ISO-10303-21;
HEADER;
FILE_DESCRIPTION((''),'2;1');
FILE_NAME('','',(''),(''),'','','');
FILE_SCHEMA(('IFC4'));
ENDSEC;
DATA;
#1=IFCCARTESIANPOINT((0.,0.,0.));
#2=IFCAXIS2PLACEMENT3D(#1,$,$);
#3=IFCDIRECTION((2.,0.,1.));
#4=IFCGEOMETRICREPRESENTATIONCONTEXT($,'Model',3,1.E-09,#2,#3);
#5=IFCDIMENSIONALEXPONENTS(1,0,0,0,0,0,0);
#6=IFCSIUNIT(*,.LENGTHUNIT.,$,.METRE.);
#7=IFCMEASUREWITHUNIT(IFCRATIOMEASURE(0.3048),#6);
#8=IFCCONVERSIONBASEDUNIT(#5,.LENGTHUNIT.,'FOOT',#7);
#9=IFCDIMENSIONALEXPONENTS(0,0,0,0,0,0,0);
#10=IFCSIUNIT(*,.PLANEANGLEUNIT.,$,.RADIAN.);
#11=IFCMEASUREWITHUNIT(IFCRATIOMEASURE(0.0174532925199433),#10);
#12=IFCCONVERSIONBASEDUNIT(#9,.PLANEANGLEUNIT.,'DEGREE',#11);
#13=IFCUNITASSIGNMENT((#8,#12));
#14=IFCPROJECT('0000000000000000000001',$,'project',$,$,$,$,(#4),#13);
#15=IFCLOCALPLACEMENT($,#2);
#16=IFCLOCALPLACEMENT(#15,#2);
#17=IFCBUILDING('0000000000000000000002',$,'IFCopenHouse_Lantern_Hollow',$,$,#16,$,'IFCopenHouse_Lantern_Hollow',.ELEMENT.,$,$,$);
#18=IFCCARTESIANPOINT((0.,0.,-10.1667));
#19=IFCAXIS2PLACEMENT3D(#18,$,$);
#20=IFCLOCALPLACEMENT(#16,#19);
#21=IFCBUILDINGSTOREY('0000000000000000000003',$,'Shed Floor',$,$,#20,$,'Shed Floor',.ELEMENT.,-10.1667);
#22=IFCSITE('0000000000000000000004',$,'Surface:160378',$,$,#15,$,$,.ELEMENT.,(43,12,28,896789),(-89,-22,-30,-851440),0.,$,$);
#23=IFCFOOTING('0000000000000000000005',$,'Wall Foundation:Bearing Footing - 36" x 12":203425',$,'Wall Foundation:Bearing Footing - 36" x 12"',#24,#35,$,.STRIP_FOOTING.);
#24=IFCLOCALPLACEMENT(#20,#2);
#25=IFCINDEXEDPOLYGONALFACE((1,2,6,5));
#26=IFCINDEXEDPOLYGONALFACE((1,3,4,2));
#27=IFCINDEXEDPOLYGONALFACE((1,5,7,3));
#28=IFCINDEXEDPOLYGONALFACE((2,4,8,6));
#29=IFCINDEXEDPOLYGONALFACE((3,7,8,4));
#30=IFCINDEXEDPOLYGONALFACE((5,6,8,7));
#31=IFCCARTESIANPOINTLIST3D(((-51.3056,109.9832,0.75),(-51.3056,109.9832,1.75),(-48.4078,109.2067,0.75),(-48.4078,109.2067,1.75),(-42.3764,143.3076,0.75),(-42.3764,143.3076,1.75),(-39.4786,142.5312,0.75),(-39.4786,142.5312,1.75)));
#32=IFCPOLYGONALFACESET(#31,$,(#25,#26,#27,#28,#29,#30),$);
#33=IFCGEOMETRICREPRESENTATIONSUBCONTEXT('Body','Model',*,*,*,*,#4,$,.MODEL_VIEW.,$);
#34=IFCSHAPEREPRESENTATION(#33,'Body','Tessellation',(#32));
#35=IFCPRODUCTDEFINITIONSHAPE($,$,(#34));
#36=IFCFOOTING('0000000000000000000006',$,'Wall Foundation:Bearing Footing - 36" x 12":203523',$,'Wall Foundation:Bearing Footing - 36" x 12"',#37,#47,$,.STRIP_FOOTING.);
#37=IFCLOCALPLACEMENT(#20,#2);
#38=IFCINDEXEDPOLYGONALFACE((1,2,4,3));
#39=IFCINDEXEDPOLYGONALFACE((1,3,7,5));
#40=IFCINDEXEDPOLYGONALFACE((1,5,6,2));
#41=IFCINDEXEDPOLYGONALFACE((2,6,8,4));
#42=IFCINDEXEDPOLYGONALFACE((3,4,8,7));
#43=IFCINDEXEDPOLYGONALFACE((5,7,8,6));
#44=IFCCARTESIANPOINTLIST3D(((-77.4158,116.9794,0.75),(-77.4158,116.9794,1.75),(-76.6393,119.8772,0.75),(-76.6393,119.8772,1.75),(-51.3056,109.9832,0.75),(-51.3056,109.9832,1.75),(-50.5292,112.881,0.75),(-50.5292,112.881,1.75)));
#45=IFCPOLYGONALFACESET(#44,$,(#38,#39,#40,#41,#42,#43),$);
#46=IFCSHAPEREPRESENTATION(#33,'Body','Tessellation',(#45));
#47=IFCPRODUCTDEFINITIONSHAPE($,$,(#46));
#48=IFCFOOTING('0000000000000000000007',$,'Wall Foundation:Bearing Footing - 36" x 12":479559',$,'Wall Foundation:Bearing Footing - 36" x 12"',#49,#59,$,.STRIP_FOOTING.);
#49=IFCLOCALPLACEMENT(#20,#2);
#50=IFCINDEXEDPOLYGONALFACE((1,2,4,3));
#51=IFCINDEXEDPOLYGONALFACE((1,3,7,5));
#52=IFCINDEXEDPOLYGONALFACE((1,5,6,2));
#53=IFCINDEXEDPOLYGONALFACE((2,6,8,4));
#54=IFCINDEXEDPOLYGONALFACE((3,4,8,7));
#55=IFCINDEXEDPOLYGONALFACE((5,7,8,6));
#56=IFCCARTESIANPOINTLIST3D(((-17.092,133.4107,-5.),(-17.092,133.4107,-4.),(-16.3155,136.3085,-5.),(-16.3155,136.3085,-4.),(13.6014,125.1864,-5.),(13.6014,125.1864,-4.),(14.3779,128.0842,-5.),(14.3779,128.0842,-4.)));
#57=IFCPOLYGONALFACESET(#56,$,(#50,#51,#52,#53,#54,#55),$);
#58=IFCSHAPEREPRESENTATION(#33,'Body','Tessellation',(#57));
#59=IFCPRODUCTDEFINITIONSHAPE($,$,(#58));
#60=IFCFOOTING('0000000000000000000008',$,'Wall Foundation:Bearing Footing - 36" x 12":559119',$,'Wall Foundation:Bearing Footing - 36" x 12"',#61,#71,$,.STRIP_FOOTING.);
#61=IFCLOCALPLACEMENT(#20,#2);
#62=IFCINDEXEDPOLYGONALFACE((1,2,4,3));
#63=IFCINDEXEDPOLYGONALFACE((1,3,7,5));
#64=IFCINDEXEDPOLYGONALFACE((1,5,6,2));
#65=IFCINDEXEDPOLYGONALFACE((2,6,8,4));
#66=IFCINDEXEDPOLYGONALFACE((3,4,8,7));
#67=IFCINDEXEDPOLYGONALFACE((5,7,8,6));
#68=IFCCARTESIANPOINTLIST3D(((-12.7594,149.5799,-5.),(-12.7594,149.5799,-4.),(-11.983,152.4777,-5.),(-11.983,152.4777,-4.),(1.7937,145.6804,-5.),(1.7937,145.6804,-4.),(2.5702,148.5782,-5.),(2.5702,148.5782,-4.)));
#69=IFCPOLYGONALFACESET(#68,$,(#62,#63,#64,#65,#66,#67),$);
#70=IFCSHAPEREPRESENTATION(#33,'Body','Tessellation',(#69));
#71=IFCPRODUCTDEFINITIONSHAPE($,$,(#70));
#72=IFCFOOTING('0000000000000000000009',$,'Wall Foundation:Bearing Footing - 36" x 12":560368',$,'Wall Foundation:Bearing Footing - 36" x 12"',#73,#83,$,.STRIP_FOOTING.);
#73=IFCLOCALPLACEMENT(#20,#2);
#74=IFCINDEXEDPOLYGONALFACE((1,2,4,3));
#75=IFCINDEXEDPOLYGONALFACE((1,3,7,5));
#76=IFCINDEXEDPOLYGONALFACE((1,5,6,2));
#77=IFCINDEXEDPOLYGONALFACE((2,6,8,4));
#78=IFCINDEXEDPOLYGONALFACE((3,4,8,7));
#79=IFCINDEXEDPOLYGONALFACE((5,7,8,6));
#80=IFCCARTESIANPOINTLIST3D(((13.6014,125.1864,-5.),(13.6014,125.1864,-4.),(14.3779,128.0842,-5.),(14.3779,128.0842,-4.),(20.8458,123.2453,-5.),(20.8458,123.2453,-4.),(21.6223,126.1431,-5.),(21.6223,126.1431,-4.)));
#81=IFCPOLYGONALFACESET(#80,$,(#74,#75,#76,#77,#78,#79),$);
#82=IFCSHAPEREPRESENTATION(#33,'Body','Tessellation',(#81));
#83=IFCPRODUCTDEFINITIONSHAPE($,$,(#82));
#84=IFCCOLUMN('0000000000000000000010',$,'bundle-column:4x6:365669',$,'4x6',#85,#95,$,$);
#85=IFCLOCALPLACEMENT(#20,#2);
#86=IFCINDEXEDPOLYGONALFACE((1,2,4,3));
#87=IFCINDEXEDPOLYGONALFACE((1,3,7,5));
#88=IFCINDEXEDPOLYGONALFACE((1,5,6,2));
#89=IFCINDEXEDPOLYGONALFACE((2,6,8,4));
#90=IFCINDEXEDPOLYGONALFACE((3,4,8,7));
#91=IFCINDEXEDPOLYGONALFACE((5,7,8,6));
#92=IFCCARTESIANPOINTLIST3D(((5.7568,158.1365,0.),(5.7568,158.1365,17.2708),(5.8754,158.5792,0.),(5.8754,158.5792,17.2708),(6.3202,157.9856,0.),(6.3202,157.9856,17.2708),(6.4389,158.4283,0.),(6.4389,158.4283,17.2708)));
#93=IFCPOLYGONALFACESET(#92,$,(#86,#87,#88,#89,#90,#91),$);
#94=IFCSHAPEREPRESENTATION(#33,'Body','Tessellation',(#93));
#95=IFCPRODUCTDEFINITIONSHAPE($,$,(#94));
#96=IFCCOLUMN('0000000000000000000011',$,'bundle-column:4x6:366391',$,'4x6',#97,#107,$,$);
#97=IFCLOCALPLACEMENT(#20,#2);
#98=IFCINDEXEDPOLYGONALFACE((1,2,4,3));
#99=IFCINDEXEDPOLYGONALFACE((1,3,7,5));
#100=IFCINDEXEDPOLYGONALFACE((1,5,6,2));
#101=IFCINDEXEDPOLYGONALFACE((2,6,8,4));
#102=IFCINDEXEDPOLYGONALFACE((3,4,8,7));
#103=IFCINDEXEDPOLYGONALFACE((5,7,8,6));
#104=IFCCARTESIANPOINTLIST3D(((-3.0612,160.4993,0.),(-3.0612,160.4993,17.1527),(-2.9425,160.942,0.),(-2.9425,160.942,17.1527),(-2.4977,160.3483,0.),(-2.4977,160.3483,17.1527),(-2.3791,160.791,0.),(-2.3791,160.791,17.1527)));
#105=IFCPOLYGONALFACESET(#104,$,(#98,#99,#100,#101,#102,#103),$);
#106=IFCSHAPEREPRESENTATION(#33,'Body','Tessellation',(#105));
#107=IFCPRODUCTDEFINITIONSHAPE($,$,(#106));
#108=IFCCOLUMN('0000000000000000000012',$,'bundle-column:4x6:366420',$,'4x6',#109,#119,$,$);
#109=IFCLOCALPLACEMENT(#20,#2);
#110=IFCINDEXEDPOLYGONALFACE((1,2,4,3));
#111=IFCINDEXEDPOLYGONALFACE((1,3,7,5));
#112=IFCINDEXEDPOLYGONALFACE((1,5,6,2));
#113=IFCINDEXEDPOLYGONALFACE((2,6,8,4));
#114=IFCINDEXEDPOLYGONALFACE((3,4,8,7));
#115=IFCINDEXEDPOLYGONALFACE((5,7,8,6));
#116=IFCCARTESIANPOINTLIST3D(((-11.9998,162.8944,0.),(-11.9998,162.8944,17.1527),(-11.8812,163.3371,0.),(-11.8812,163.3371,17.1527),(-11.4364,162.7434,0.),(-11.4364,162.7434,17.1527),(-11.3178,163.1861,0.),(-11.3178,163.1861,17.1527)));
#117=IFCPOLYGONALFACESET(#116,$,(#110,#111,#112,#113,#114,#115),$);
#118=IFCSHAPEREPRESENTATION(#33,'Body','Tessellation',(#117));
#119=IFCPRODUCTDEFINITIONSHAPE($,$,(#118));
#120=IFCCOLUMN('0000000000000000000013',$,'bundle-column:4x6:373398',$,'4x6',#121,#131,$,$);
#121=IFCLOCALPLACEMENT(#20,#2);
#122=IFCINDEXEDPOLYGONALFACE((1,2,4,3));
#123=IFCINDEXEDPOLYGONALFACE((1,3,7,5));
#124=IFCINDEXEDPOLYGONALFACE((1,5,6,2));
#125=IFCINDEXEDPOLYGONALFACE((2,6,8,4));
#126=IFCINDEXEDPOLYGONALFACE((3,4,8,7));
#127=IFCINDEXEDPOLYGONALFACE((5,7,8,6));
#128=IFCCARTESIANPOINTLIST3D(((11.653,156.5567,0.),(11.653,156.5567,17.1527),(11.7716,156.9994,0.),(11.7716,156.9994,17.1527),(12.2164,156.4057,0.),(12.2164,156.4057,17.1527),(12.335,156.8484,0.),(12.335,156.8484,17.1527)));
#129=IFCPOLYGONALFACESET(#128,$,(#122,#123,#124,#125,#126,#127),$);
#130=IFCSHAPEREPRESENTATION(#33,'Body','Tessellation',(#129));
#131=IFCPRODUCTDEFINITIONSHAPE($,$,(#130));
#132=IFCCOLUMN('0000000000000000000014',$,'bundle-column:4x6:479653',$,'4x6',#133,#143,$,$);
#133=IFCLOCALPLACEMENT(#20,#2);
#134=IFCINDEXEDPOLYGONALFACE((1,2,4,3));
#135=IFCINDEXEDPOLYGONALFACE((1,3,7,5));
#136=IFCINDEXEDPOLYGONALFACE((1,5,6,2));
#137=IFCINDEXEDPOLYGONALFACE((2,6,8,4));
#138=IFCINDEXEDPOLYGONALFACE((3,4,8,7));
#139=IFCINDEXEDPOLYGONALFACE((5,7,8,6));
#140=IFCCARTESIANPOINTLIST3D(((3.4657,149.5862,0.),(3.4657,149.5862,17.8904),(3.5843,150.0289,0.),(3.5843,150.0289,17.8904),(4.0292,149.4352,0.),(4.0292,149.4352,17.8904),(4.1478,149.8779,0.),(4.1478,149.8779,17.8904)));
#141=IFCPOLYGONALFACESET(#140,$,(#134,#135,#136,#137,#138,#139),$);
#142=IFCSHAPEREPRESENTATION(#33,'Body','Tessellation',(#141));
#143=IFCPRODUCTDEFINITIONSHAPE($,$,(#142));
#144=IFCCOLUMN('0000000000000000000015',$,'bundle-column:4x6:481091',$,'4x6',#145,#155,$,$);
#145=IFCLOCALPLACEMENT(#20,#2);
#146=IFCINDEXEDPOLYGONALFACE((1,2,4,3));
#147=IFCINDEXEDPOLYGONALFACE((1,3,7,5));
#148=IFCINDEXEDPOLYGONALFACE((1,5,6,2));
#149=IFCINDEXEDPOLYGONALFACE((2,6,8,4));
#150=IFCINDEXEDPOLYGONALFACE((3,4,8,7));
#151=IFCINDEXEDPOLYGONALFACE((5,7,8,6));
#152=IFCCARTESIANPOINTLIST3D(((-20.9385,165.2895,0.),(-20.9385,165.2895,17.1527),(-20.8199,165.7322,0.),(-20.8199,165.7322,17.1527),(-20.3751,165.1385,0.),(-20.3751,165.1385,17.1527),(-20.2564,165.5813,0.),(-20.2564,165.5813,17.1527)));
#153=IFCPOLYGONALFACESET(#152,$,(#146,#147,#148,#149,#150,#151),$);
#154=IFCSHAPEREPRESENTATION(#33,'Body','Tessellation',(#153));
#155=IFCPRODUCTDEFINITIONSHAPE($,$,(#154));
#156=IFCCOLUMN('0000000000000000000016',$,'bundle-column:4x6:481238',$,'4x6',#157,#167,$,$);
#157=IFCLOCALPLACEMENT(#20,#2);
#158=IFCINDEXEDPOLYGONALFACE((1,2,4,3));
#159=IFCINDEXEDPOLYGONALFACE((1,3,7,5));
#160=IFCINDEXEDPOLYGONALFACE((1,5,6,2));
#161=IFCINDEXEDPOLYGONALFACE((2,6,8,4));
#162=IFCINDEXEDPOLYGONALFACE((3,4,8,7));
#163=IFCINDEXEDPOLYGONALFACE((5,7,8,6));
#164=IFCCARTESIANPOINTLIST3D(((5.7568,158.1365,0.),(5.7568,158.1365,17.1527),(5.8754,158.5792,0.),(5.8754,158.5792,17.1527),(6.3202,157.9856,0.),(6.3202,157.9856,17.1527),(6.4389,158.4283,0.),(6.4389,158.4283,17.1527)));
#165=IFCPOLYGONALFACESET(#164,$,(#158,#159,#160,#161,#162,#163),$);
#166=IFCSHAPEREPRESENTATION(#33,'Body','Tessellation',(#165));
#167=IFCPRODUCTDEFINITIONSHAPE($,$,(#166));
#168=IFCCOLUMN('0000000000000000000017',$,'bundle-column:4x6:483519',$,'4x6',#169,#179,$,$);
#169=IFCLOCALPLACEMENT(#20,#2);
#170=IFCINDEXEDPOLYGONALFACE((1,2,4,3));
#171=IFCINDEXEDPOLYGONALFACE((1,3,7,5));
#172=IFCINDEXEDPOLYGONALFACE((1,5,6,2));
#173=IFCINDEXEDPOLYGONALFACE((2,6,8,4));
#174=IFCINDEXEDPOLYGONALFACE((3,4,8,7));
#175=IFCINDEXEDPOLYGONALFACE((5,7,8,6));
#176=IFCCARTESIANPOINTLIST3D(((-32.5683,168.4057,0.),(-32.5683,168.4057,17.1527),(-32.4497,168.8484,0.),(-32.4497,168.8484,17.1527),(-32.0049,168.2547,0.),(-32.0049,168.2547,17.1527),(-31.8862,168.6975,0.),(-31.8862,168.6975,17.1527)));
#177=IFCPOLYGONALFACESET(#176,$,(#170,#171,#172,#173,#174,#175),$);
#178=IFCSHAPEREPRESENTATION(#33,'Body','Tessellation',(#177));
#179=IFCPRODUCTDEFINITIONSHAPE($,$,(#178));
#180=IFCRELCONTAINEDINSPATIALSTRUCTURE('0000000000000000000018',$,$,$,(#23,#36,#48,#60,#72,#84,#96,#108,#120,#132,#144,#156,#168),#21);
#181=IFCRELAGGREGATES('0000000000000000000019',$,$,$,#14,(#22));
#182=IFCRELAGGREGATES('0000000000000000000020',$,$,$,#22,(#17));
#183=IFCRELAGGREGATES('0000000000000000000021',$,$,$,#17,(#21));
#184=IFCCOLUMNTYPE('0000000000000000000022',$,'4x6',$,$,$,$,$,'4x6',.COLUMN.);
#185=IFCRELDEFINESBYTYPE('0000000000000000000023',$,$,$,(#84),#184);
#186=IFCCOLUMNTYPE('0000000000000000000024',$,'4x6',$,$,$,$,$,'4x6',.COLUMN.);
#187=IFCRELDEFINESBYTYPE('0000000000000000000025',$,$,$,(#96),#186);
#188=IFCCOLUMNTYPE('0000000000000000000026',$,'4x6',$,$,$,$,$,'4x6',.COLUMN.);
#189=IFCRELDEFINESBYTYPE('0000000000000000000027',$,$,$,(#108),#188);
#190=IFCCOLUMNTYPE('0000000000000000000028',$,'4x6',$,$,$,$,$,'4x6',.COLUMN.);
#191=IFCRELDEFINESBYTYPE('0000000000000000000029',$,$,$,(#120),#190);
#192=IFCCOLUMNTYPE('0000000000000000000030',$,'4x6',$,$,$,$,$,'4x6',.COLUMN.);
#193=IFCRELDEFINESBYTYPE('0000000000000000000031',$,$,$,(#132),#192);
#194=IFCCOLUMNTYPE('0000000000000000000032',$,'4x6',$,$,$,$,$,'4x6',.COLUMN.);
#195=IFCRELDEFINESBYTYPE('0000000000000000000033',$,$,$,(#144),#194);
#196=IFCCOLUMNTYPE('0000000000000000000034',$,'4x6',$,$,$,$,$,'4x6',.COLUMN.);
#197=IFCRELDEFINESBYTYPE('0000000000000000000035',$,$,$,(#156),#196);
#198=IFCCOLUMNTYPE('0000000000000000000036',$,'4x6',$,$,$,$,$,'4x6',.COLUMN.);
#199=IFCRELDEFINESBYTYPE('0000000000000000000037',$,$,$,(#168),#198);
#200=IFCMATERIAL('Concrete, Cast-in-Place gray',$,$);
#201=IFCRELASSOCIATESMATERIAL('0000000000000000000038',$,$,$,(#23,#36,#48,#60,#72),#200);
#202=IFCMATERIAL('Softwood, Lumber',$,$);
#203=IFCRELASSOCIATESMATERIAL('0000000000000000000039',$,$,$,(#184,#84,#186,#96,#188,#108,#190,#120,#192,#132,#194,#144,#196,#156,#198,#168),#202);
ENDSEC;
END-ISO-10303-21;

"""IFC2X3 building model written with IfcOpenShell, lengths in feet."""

from ifc_helpers import new_model, entity, si_unit, converted_unit, direction, frame, frame_2d, origin, origin_2d_with_axis, place, context, subcontext, project, spatial, rectangle, extrude, source, transform, mapped, material, type_object, type_shapes, element, save


model = new_model("IFC2X3")

# Units and contexts
model_context = context("Model", 3, precision=1e-09, world=origin(), true_north=direction((2.0, 0.0, 1.0)))
body_context = subcontext(model_context, "Body", "Model", "MODEL_VIEW")
ifc_project = project(units=[converted_unit("LENGTHUNIT", "FOOT", entity("IfcRatioMeasure", 0.3048), si_unit("LENGTHUNIT", "METRE"), dimensions=[1, 0, 0, 0, 0, 0, 0]), converted_unit("PLANEANGLEUNIT", "DEGREE", entity("IfcRatioMeasure", 0.0174532925199433), si_unit("PLANEANGLEUNIT", "RADIAN"), dimensions=[0, 0, 0, 0, 0, 0, 0])], contexts=[model_context])

# Site, building, storey
site_placement = place(None, origin())
site = spatial("IfcSite", under=ifc_project, at=site_placement, Name="Surface:160378", CompositionType="ELEMENT", RefLatitude=(43, 12, 28, 896789), RefLongitude=(-89, -22, -30, -851440), RefElevation=0.0)
building_placement = place(site_placement, origin())
building = spatial("IfcBuilding", under=site, at=building_placement, Name="IFCopenHouse_Lantern_Hollow", LongName="IFCopenHouse_Lantern_Hollow", CompositionType="ELEMENT")
storey_placement = place(building_placement, frame((0.0, 0.0, -10.1667)))
storey = spatial("IfcBuildingStorey", under=building, at=storey_placement, Name="Shed Floor", LongName="Shed Floor", CompositionType="ELEMENT", Elevation=-10.1667)

# Footings
ifc_material_1 = material(Name="Concrete, Cast-in-Place gray")
footing_1_placement = place(storey_placement, origin())
element("IfcFooting", 1, at=footing_1_placement, inside=storey, material=ifc_material_1, Name="Wall Foundation:Bearing Footing - 36\" x 12\":203425", ObjectType="Wall Foundation:Bearing Footing - 36\" x 12\"", PredefinedType="STRIP_FOOTING", context=body_context, shape_type="SweptSolid", body=[
    extrude(rectangle(XDim=34.5, YDim=3.0, at=frame_2d((0.0, 0.0), x_axis=(1.0, 0.0))), frame((-45.3921, 126.2572, 0.75), z_axis=(0.0, 0.0, 1.0), x_axis=(-0.258819, -0.965926, 0.0)), (0.0, 0.0, 1.0), 1.0),
])
footing_2_placement = place(storey_placement, origin())
element("IfcFooting", 2, at=footing_2_placement, inside=storey, material=ifc_material_1, Name="Wall Foundation:Bearing Footing - 36\" x 12\":203523", ObjectType="Wall Foundation:Bearing Footing - 36\" x 12\"", PredefinedType="STRIP_FOOTING", context=body_context, shape_type="SweptSolid", body=[
    extrude(rectangle(XDim=27.0313, YDim=3.0, at=frame_2d((0.0, 0.0), x_axis=(1.0, 0.0))), frame((-63.9725, 114.9302, 0.75), z_axis=(0.0, 0.0, 1.0), x_axis=(0.965926, -0.258819, 0.0)), (0.0, 0.0, 1.0), 1.0),
])
footing_3_placement = place(storey_placement, origin())
element("IfcFooting", 3, at=footing_3_placement, inside=storey, material=ifc_material_1, Name="Wall Foundation:Bearing Footing - 36\" x 12\":479559", ObjectType="Wall Foundation:Bearing Footing - 36\" x 12\"", PredefinedType="STRIP_FOOTING", context=body_context, shape_type="SweptSolid", body=[
    extrude(rectangle(XDim=31.7761, YDim=3.0, at=origin_2d_with_axis()), frame((-1.357, 130.7474, -5.0), z_axis=(0.0, 0.0, 1.0), x_axis=(0.965926, -0.258819, 0.0)), (0.0, 0.0, 1.0), 1.0),
])
footing_4_placement = place(storey_placement, origin())
element("IfcFooting", 4, at=footing_4_placement, inside=storey, material=ifc_material_1, Name="Wall Foundation:Bearing Footing - 36\" x 12\":559119", ObjectType="Wall Foundation:Bearing Footing - 36\" x 12\"", PredefinedType="STRIP_FOOTING", context=body_context, shape_type="SweptSolid", body=[
    extrude(rectangle(XDim=15.0665, YDim=3.0, at=frame_2d((0.0, 0.0), x_axis=(1.0, 0.0))), frame((-5.0946, 149.079, -5.0), z_axis=(0.0, 0.0, 1.0), x_axis=(0.965926, -0.258819, 0.0)), (0.0, 0.0, 1.0), 1.0),
])
footing_5_placement = place(storey_placement, origin())
element("IfcFooting", 5, at=footing_5_placement, inside=storey, material=ifc_material_1, Name="Wall Foundation:Bearing Footing - 36\" x 12\":560368", ObjectType="Wall Foundation:Bearing Footing - 36\" x 12\"", PredefinedType="STRIP_FOOTING", context=body_context, shape_type="SweptSolid", body=[
    extrude(rectangle(XDim=7.5, YDim=3.0, at=frame_2d((0.0, 0.0), x_axis=(1.0, 0.0))), frame((17.6119, 125.6647, -5.0), z_axis=(0.0, 0.0, 1.0), x_axis=(0.965926, -0.258819, 0.0)), (0.0, 0.0, 1.0), 1.0),
])

# Columns
ifc_material_2 = material(Name="Softwood, Lumber")
column_type_1 = type_object("IfcColumnType", Name="4x6", ElementType="4x6", PredefinedType="COLUMN", material=ifc_material_2)
shared_shape_1 = source(origin(), body_context, "Body", "SweptSolid", [
    extrude(rectangle(XDim=0.5833, YDim=0.4583, at=frame_2d((0.0, 0.0), x_axis=(1.0, 0.0))), frame((6.0978, 158.2824, -10.1667), z_axis=(0.0, 0.0, 1.0), x_axis=(-0.965926, 0.258819, 0.0)), (0.0, 0.0, 1.0), 17.2708),
])
type_shapes(column_type_1, [shared_shape_1])
column_1_placement = place(storey_placement, frame((0.0, 0.0, 10.1667)))
element("IfcColumn", 6, at=column_1_placement, inside=storey, type_object=column_type_1, material=ifc_material_2, Name="bundle-column:4x6:365669", ObjectType="4x6", context=body_context, shape_type="MappedRepresentation", body=[
    mapped(shared_shape_1, transform((0.0, 0.0, 0.0), scale=1.0)),
])
column_type_2 = type_object("IfcColumnType", Name="4x6", ElementType="4x6", PredefinedType="COLUMN", material=ifc_material_2)
shared_shape_2 = source(origin(), body_context, "Body", "SweptSolid", [
    extrude(rectangle(XDim=0.5833, YDim=0.4583, at=origin_2d_with_axis()), frame((-2.7201, 160.6452, -10.1667), z_axis=(0.0, 0.0, 1.0), x_axis=(-0.965926, 0.258819, 0.0)), (0.0, 0.0, 1.0), 17.1527),
])
type_shapes(column_type_2, [shared_shape_2])
column_2_placement = place(storey_placement, frame((0.0, 0.0, 10.1667)))
element("IfcColumn", 7, at=column_2_placement, inside=storey, type_object=column_type_2, material=ifc_material_2, Name="bundle-column:4x6:366391", ObjectType="4x6", context=body_context, shape_type="MappedRepresentation", body=[
    mapped(shared_shape_2, transform((0.0, 0.0, 0.0), scale=1.0)),
])
column_type_3 = type_object("IfcColumnType", Name="4x6", ElementType="4x6", PredefinedType="COLUMN", material=ifc_material_2)
shared_shape_3 = source(origin(), body_context, "Body", "SweptSolid", [
    extrude(rectangle(XDim=0.5833, YDim=0.4583, at=frame_2d((0.0, 0.0), x_axis=(1.0, 0.0))), frame((-11.6588, 163.0403, -10.1667), z_axis=(0.0, 0.0, 1.0), x_axis=(-0.965926, 0.258819, 0.0)), (0.0, 0.0, 1.0), 17.1527),
])
type_shapes(column_type_3, [shared_shape_3])
column_3_placement = place(storey_placement, frame((0.0, 0.0, 10.1667)))
element("IfcColumn", 8, at=column_3_placement, inside=storey, type_object=column_type_3, material=ifc_material_2, Name="bundle-column:4x6:366420", ObjectType="4x6", context=body_context, shape_type="MappedRepresentation", body=[
    mapped(shared_shape_3, transform((0.0, 0.0, 0.0), scale=1.0)),
])
column_type_4 = type_object("IfcColumnType", Name="4x6", ElementType="4x6", PredefinedType="COLUMN", material=ifc_material_2)
shared_shape_4 = source(origin(), body_context, "Body", "SweptSolid", [
    extrude(rectangle(XDim=0.5833, YDim=0.4583, at=frame_2d((0.0, 0.0), x_axis=(1.0, 0.0))), frame((11.994, 156.7025, -10.1667), z_axis=(0.0, 0.0, 1.0), x_axis=(-0.965926, 0.258819, 0.0)), (0.0, 0.0, 1.0), 17.1527),
])
type_shapes(column_type_4, [shared_shape_4])
column_4_placement = place(storey_placement, frame((0.0, 0.0, 10.1667)))
element("IfcColumn", 9, at=column_4_placement, inside=storey, type_object=column_type_4, material=ifc_material_2, Name="bundle-column:4x6:373398", ObjectType="4x6", context=body_context, shape_type="MappedRepresentation", body=[
    mapped(shared_shape_4, transform((0.0, 0.0, 0.0), scale=1.0)),
])
column_type_5 = type_object("IfcColumnType", Name="4x6", ElementType="4x6", PredefinedType="COLUMN", material=ifc_material_2)
shared_shape_5 = source(origin(), body_context, "Body", "SweptSolid", [
    extrude(rectangle(XDim=0.5833, YDim=0.4583, at=frame_2d((0.0, 0.0), x_axis=(1.0, 0.0))), frame((3.8068, 149.732, -10.1667), z_axis=(0.0, 0.0, 1.0), x_axis=(-0.965926, 0.258819, 0.0)), (0.0, 0.0, 1.0), 17.8904),
])
type_shapes(column_type_5, [shared_shape_5])
column_5_placement = place(storey_placement, frame((0.0, 0.0, 10.1667)))
element("IfcColumn", 10, at=column_5_placement, inside=storey, type_object=column_type_5, material=ifc_material_2, Name="bundle-column:4x6:479653", ObjectType="4x6", context=body_context, shape_type="MappedRepresentation", body=[
    mapped(shared_shape_5, transform((0.0, 0.0, 0.0), scale=1.0)),
])
column_type_6 = type_object("IfcColumnType", Name="4x6", ElementType="4x6", PredefinedType="COLUMN", material=ifc_material_2)
shared_shape_6 = source(origin(), body_context, "Body", "SweptSolid", [
    extrude(rectangle(XDim=0.5833, YDim=0.4583, at=frame_2d((0.0, 0.0), x_axis=(1.0, 0.0))), frame((-20.5975, 165.4354, -10.1667), z_axis=(0.0, 0.0, 1.0), x_axis=(-0.965926, 0.258819, 0.0)), (0.0, 0.0, 1.0), 17.1527),
])
type_shapes(column_type_6, [shared_shape_6])
column_6_placement = place(storey_placement, frame((0.0, 0.0, 10.1667)))
element("IfcColumn", 11, at=column_6_placement, inside=storey, type_object=column_type_6, material=ifc_material_2, Name="bundle-column:4x6:481091", ObjectType="4x6", context=body_context, shape_type="MappedRepresentation", body=[
    mapped(shared_shape_6, transform((0.0, 0.0, 0.0), scale=1.0)),
])
column_type_7 = type_object("IfcColumnType", Name="4x6", ElementType="4x6", PredefinedType="COLUMN", material=ifc_material_2)
shared_shape_7 = source(origin(), body_context, "Body", "SweptSolid", [
    extrude(rectangle(XDim=0.5833, YDim=0.4583, at=frame_2d((0.0, 0.0), x_axis=(1.0, 0.0))), frame((6.0978, 158.2824, -10.1667), z_axis=(0.0, 0.0, 1.0), x_axis=(-0.965926, 0.258819, 0.0)), (0.0, 0.0, 1.0), 17.1527),
])
type_shapes(column_type_7, [shared_shape_7])
column_7_placement = place(storey_placement, frame((0.0, 0.0, 10.1667)))
element("IfcColumn", 12, at=column_7_placement, inside=storey, type_object=column_type_7, material=ifc_material_2, Name="bundle-column:4x6:481238", ObjectType="4x6", context=body_context, shape_type="MappedRepresentation", body=[
    mapped(shared_shape_7, transform((0.0, 0.0, 0.0), scale=1.0)),
])
column_type_8 = type_object("IfcColumnType", Name="4x6", ElementType="4x6", PredefinedType="COLUMN", material=ifc_material_2)
shared_shape_8 = source(origin(), body_context, "Body", "SweptSolid", [
    extrude(rectangle(XDim=0.5833, YDim=0.4583, at=origin_2d_with_axis()), frame((-32.2273, 168.5516, -10.1667), z_axis=(0.0, 0.0, 1.0), x_axis=(-0.965926, 0.258819, 0.0)), (0.0, 0.0, 1.0), 17.1527),
])
type_shapes(column_type_8, [shared_shape_8])
column_8_placement = place(storey_placement, frame((0.0, 0.0, 10.1667)))
element("IfcColumn", 13, at=column_8_placement, inside=storey, type_object=column_type_8, material=ifc_material_2, Name="bundle-column:4x6:483519", ObjectType="4x6", context=body_context, shape_type="MappedRepresentation", body=[
    mapped(shared_shape_8, transform((0.0, 0.0, 0.0), scale=1.0)),
])

save(model, "model.ifc")
